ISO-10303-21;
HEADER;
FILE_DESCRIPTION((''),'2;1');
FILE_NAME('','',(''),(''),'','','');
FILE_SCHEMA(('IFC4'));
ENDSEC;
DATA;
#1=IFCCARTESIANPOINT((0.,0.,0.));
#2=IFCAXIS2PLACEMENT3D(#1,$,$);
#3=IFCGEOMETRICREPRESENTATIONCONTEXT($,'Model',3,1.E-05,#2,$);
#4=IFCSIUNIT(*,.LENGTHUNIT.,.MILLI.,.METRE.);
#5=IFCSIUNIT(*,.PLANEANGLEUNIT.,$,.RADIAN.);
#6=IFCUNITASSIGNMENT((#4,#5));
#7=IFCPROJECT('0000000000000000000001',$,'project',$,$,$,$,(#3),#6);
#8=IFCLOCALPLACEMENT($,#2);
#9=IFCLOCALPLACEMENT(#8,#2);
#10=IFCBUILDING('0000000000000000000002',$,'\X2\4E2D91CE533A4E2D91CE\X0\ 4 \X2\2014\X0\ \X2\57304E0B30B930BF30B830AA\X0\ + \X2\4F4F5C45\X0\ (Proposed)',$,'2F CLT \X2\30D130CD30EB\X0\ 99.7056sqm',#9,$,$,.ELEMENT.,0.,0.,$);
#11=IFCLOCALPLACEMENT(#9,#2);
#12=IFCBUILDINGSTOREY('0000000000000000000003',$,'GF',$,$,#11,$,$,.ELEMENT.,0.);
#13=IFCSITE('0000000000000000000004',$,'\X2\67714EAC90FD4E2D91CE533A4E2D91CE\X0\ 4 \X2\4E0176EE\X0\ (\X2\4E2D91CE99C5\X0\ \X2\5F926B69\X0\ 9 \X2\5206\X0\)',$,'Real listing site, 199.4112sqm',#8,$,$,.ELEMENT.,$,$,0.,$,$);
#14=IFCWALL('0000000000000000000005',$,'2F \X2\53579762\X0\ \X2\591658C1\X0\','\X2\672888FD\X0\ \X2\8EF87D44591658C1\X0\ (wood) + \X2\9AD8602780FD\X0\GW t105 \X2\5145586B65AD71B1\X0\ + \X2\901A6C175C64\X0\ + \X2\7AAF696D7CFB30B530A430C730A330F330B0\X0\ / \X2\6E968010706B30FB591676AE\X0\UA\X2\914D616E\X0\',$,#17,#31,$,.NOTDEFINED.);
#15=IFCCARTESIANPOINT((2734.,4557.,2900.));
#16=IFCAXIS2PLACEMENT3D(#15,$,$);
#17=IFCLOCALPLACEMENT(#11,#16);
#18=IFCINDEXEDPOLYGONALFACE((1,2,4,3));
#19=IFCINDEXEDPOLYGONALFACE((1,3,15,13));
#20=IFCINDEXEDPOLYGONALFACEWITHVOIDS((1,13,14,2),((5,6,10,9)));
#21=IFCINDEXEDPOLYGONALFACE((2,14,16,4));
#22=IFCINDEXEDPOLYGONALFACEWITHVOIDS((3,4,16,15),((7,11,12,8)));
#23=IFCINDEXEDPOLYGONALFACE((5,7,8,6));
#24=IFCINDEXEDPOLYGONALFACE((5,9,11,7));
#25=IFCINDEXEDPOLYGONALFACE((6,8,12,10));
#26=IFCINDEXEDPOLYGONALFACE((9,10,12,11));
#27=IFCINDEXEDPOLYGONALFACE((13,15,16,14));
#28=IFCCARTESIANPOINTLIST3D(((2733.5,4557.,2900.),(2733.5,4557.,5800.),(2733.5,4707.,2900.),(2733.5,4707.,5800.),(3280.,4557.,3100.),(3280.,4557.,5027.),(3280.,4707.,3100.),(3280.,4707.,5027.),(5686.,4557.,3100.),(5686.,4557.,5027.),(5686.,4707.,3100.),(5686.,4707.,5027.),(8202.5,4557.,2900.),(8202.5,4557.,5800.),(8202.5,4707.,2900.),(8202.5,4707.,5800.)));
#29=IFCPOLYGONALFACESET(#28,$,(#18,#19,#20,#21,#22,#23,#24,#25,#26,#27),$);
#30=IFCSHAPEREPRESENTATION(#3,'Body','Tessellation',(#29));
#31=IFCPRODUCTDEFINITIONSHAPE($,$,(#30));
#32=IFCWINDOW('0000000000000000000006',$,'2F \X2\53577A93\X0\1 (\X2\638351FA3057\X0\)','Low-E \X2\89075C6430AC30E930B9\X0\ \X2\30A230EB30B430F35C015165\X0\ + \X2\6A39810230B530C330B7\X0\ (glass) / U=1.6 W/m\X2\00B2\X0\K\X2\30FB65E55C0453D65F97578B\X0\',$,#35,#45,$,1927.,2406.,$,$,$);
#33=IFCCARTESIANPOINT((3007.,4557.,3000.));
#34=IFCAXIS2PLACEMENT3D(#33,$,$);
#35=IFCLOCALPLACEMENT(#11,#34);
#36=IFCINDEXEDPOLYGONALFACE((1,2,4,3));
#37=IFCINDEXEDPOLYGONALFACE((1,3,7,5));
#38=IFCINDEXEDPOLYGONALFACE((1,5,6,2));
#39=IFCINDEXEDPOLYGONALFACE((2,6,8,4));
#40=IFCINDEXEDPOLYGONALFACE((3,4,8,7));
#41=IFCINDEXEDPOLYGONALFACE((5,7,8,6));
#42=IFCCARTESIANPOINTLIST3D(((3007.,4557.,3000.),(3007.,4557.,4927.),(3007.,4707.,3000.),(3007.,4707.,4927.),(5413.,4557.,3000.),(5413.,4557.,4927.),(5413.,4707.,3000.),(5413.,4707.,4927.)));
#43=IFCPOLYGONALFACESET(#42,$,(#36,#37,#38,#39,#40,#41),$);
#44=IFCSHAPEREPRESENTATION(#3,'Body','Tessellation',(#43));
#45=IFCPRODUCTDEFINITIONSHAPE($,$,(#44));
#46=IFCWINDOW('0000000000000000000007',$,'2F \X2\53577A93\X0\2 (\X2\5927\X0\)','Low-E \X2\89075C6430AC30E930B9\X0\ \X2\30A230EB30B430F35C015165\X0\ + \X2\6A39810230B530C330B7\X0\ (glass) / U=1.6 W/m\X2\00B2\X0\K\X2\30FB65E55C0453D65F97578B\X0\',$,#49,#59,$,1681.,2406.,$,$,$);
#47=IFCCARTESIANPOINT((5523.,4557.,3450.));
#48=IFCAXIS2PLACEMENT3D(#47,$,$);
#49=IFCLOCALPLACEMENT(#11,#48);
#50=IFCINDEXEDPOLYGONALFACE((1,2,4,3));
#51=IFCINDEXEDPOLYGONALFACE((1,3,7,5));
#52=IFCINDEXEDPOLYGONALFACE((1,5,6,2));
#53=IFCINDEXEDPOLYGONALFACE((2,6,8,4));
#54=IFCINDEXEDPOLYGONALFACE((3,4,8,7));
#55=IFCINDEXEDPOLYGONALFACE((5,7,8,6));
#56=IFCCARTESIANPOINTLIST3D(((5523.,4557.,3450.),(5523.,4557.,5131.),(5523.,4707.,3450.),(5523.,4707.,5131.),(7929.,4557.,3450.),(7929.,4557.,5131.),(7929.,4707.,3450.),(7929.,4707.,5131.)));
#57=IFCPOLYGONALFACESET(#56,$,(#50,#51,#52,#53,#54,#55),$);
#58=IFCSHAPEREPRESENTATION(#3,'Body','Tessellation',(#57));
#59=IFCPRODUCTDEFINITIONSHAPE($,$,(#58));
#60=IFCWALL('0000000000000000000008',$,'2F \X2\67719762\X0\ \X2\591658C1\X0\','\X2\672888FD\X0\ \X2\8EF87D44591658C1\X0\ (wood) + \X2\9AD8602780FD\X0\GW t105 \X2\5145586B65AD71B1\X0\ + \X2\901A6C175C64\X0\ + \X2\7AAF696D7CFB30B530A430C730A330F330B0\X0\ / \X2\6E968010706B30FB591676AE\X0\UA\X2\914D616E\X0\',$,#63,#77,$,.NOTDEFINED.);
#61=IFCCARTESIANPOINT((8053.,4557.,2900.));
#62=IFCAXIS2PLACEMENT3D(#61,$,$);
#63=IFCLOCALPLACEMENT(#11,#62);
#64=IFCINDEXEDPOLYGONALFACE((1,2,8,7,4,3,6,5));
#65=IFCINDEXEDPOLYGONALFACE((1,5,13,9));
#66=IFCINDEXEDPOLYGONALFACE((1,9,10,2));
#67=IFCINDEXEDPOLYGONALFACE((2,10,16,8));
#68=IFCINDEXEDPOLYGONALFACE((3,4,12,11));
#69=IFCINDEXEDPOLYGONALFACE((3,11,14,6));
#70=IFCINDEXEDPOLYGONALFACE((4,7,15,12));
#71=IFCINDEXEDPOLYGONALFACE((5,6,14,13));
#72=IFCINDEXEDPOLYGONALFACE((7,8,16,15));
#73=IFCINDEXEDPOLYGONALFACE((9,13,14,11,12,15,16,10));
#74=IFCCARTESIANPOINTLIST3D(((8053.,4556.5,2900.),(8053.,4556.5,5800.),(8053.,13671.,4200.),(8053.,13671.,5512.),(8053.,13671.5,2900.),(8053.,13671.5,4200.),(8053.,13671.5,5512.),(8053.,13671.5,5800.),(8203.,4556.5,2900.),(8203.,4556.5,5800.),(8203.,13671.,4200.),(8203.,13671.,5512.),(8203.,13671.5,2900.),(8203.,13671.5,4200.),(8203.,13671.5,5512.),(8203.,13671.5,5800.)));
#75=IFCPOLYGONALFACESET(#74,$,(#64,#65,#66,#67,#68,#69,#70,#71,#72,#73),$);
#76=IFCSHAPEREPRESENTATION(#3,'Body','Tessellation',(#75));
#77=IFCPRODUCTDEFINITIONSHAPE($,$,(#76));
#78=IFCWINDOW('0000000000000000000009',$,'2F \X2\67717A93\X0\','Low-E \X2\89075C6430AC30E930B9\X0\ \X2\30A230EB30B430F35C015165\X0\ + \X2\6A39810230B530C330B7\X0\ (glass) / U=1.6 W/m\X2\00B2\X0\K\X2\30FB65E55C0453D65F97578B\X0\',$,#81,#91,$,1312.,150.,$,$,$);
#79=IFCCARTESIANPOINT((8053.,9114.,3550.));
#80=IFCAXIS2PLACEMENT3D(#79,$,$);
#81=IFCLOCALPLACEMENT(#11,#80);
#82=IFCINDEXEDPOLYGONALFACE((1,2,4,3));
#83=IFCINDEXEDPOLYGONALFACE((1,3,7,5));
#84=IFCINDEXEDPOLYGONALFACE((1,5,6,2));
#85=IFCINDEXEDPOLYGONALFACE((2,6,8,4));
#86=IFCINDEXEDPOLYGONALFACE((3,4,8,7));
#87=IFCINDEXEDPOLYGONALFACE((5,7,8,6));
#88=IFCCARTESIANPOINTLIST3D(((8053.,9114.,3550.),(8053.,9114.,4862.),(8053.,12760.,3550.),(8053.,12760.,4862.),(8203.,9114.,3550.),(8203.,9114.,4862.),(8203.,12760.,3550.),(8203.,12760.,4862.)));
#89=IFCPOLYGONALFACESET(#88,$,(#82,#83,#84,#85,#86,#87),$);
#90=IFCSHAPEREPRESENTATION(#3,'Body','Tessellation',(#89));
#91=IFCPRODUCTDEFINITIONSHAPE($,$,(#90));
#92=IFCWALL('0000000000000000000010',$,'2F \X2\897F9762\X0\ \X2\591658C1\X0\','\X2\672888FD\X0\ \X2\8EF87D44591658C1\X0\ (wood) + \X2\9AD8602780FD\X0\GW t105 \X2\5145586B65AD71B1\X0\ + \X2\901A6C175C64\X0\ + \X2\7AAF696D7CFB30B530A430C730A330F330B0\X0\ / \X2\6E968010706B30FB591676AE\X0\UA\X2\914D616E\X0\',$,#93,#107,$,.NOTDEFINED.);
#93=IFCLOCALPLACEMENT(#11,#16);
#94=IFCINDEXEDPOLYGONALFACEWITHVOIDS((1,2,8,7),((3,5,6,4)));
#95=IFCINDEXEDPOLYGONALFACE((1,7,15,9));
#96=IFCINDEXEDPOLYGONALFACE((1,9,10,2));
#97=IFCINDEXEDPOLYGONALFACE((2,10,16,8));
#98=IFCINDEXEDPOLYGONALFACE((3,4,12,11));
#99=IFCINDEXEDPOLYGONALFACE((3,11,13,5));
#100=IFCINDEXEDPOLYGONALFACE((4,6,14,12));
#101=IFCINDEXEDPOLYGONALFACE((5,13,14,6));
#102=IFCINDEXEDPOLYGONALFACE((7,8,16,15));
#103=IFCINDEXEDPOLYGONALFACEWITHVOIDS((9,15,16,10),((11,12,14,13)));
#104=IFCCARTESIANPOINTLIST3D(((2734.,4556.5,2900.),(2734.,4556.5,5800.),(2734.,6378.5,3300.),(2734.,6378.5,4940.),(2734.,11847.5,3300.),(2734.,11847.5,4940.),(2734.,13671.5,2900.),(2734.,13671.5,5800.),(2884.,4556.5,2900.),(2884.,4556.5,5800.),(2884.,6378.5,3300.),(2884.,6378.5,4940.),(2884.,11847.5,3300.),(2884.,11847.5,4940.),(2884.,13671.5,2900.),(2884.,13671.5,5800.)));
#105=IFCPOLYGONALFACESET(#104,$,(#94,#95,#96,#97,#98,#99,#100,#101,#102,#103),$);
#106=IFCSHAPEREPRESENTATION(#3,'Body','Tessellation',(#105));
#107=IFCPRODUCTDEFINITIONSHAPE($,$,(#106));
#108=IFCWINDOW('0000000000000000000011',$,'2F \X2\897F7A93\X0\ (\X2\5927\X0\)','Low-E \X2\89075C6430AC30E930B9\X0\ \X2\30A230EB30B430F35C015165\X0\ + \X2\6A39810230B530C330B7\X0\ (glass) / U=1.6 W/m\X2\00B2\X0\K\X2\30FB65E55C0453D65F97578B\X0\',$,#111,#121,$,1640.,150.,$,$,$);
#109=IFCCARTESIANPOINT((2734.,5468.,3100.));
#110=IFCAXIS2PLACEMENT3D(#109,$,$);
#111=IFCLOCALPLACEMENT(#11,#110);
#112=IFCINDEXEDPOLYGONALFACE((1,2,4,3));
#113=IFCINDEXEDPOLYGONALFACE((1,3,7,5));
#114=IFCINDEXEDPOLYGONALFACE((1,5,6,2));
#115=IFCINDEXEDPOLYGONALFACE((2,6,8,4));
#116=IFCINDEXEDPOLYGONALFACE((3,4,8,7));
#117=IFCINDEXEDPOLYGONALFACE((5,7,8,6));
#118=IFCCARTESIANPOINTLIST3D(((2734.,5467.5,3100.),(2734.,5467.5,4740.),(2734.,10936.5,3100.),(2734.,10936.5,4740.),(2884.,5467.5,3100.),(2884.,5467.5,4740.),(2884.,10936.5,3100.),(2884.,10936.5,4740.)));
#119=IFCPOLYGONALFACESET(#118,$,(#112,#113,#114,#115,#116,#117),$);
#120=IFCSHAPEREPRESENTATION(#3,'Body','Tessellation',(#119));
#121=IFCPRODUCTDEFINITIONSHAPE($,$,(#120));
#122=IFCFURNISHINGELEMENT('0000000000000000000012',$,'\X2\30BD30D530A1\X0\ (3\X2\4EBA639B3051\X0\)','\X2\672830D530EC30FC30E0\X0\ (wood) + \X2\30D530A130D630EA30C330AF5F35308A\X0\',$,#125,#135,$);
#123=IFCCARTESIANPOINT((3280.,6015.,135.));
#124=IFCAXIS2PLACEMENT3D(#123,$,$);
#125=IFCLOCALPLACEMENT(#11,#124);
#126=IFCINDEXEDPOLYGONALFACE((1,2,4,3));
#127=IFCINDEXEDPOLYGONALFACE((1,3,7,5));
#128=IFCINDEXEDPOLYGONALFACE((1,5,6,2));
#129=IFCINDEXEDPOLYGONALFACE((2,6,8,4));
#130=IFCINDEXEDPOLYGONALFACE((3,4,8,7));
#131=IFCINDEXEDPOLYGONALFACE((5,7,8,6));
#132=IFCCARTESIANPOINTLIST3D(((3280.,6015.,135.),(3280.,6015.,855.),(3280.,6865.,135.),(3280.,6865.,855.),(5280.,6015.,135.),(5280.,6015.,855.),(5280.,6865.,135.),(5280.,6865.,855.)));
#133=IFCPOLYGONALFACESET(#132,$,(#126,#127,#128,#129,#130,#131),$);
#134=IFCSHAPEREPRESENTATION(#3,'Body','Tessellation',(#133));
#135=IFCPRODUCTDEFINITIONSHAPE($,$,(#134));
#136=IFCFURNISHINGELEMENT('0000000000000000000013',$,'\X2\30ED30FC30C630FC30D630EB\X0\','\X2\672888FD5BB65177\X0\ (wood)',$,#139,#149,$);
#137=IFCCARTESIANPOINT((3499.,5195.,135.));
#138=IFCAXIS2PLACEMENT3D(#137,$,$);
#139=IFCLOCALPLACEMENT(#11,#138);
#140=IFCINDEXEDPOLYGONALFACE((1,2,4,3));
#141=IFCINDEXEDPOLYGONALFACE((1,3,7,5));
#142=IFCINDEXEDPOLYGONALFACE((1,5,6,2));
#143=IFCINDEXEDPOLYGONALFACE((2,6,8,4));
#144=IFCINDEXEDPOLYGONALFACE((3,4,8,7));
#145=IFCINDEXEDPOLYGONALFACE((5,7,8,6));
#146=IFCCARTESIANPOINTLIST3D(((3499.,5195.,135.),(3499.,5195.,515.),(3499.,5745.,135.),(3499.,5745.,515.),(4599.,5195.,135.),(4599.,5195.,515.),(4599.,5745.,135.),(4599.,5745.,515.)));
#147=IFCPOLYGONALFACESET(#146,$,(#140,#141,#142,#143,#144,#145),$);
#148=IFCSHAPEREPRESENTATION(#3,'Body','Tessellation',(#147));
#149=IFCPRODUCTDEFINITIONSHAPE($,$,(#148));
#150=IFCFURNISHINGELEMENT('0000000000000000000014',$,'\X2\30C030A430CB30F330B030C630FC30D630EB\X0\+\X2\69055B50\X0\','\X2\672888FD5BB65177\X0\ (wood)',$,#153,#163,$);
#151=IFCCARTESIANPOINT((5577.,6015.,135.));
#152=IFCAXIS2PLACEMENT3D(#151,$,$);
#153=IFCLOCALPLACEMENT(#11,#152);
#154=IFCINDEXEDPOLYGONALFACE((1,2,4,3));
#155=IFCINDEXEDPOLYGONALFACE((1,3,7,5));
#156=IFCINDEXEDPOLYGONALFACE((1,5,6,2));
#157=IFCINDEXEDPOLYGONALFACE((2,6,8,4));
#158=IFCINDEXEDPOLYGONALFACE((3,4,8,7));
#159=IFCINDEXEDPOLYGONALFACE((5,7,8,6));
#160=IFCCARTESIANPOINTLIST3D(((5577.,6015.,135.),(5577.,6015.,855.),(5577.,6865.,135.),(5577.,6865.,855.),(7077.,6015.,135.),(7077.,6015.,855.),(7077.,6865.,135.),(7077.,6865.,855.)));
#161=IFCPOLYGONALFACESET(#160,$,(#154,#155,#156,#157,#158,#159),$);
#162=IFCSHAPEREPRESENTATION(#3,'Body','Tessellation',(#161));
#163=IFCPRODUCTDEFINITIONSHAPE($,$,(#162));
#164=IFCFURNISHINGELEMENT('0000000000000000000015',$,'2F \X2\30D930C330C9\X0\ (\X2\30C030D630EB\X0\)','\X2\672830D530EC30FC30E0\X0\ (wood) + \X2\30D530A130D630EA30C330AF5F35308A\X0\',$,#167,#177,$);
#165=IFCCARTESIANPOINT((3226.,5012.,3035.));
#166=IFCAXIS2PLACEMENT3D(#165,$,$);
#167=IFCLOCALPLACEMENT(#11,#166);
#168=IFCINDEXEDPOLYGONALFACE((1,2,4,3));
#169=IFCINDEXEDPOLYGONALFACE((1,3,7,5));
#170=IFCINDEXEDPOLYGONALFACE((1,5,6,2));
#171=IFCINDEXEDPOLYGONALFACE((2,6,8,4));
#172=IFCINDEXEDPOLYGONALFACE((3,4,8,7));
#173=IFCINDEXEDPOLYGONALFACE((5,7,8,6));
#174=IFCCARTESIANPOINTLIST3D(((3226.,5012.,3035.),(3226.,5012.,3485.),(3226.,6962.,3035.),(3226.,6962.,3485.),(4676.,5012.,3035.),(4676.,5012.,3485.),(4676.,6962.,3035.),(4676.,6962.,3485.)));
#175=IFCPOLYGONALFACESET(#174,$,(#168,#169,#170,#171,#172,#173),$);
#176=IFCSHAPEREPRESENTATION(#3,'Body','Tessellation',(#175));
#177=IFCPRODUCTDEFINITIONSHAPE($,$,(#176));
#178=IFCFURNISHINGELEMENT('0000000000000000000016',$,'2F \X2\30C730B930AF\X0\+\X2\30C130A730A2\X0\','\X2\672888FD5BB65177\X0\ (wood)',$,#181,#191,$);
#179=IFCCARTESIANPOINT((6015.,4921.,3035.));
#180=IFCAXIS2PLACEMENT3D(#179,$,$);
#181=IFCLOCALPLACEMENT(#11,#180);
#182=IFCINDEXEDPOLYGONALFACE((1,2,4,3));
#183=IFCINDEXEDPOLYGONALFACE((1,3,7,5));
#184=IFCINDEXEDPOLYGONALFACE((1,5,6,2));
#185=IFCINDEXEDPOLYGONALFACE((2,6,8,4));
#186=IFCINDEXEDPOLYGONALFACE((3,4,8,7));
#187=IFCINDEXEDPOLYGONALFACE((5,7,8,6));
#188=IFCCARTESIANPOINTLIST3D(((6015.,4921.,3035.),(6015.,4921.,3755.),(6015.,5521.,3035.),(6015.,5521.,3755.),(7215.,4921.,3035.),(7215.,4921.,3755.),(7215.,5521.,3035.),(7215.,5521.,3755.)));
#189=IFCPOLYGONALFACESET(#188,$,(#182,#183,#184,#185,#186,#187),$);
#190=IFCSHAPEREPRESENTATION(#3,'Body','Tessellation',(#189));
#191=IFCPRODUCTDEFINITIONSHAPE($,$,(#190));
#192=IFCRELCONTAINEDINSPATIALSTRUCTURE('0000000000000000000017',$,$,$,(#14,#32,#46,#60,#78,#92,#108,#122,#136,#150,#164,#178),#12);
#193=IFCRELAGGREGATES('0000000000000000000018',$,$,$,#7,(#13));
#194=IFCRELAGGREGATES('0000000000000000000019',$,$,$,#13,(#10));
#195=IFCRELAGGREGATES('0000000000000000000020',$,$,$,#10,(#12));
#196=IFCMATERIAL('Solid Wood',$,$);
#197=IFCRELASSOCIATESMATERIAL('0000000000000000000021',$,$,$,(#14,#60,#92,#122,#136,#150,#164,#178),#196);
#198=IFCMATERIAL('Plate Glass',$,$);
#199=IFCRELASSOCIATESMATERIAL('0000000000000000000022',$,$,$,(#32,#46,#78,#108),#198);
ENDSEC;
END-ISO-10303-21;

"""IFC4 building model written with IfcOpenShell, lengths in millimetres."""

from ifc_helpers import new_model, si_unit, frame, frame_2d, origin, place, context, project, spatial, rectangle, extrude, material, element, fill, save


model = new_model("IFC4")

# Units and contexts
model_context = context("Model", 3, precision=1e-05, world=origin())
ifc_project = project(units=[si_unit("LENGTHUNIT", "METRE", prefix="MILLI"), si_unit("PLANEANGLEUNIT", "RADIAN")], contexts=[model_context])

# Site, building, storey
site_placement = place(None, origin())
site = spatial("IfcSite", under=ifc_project, at=site_placement, Name="東京都中野区中野 4 丁目 (中野駅 徒歩 9 分)", ObjectType="Real listing site, 199.4112sqm", CompositionType="ELEMENT", RefElevation=0.0)
building_placement = place(site_placement, origin())
building = spatial("IfcBuilding", under=site, at=building_placement, Name="中野区中野 4 — 地下スタジオ + 住居 (Proposed)", ObjectType="2F CLT パネル 99.7056sqm", CompositionType="ELEMENT", ElevationOfRefHeight=0.0, ElevationOfTerrain=0.0)
storey_placement = place(building_placement, origin())
storey = spatial("IfcBuildingStorey", under=building, at=storey_placement, Name="GF", CompositionType="ELEMENT", Elevation=0.0)

# Shared definitions
ifc_material_1 = material(Name="Solid Wood")

# Wall, openings, windows
wall_1_placement = place(storey_placement, frame((2734.0, 4557.0, 2900.0)))
wall_1 = element("IfcWall", 1, at=wall_1_placement, inside=storey, material=ifc_material_1, Name="2F 南面 外壁", Description="木製 軸組外壁 (wood) + 高性能GW t105 充填断熱 + 通気層 + 窯業系サイディング / 準耐火・外皮UA配慮", PredefinedType="NOTDEFINED", context=model_context, shape_type="SweptSolid", body=[
    extrude(rectangle(XDim=5469.0, YDim=150.0, at=frame_2d((2734.0, 75.0))), frame((2734.0, 4557.0, 2900.0)), (0.0, 0.0, 1.0), 2900.0),
])
opening_1_placement = place(storey_placement, frame((3007.0, 4557.0, 3000.0)))
opening_1 = element("IfcOpeningElement", 2, at=opening_1_placement, cuts=wall_1, PredefinedType="NOTDEFINED", context=model_context, shape_type="SweptSolid", body=[
    extrude(rectangle(XDim=2406.0, YDim=150.0, at=frame_2d((1203.0, 75.0))), frame((3007.0, 4557.0, 3000.0)), (0.0, 0.0, 1.0), 1927.0),
])
opening_2_placement = place(storey_placement, frame((5523.0, 4557.0, 3450.0)))
opening_2 = element("IfcOpeningElement", 3, at=opening_2_placement, cuts=wall_1, PredefinedType="NOTDEFINED", context=model_context, shape_type="SweptSolid", body=[
    extrude(rectangle(XDim=2406.0, YDim=150.0, at=frame_2d((1203.0, 75.0))), frame((5523.0, 4557.0, 3450.0)), (0.0, 0.0, 1.0), 1681.0),
])
ifc_material_2 = material(Name="Plate Glass")
window_1_placement = place(storey_placement, frame((3007.0, 4557.0, 3000.0)))
window_1 = element("IfcWindow", 4, at=window_1_placement, inside=storey, material=ifc_material_2, Name="2F 南窓1 (掃出し)", Description="Low-E 複層ガラス アルゴン封入 + 樹脂サッシ (glass) / U=1.6 W/m²K・日射取得型", OverallHeight=1927.0, OverallWidth=2406.0, context=model_context, shape_type="SweptSolid", body=[
    extrude(rectangle(XDim=2406.0, YDim=150.0, at=frame_2d((1203.0, 75.0))), frame((3007.0, 4557.0, 3000.0)), (0.0, 0.0, 1.0), 1927.0),
])
fill(opening_1, window_1)
window_2_placement = place(storey_placement, frame((5523.0, 4557.0, 3450.0)))
window_2 = element("IfcWindow", 5, at=window_2_placement, inside=storey, material=ifc_material_2, Name="2F 南窓2 (大)", Description="Low-E 複層ガラス アルゴン封入 + 樹脂サッシ (glass) / U=1.6 W/m²K・日射取得型", OverallHeight=1681.0, OverallWidth=2406.0, context=model_context, shape_type="SweptSolid", body=[
    extrude(rectangle(XDim=2406.0, YDim=150.0, at=frame_2d((1203.0, 75.0))), frame((5523.0, 4557.0, 3450.0)), (0.0, 0.0, 1.0), 1681.0),
])
fill(opening_2, window_2)

# Walls, openings, windows
wall_2_placement = place(storey_placement, frame((8053.0, 4557.0, 2900.0)))
wall_2 = element("IfcWall", 6, at=wall_2_placement, inside=storey, material=ifc_material_1, Name="2F 東面 外壁", Description="木製 軸組外壁 (wood) + 高性能GW t105 充填断熱 + 通気層 + 窯業系サイディング / 準耐火・外皮UA配慮", PredefinedType="NOTDEFINED", context=model_context, shape_type="SweptSolid", body=[
    extrude(rectangle(XDim=150.0, YDim=9115.0, at=frame_2d((75.0, 4557.0))), frame((8053.0, 4557.0, 2900.0)), (0.0, 0.0, 1.0), 2900.0),
])
opening_3_placement = place(storey_placement, frame((8053.0, 9114.0, 3550.0)))
opening_3 = element("IfcOpeningElement", 7, at=opening_3_placement, cuts=wall_2, PredefinedType="NOTDEFINED", context=model_context, shape_type="SweptSolid", body=[
    extrude(rectangle(XDim=150.0, YDim=3646.0, at=frame_2d((75.0, 1823.0))), frame((8053.0, 9114.0, 3550.0)), (0.0, 0.0, 1.0), 1312.0),
])
window_3_placement = place(storey_placement, frame((8053.0, 9114.0, 3550.0)))
window_3 = element("IfcWindow", 8, at=window_3_placement, inside=storey, material=ifc_material_2, Name="2F 東窓", Description="Low-E 複層ガラス アルゴン封入 + 樹脂サッシ (glass) / U=1.6 W/m²K・日射取得型", OverallHeight=1312.0, OverallWidth=150.0, context=model_context, shape_type="SweptSolid", body=[
    extrude(rectangle(XDim=150.0, YDim=3646.0, at=frame_2d((75.0, 1823.0))), frame((8053.0, 9114.0, 3550.0)), (0.0, 0.0, 1.0), 1312.0),
])
fill(opening_3, window_3)
wall_3_placement = place(storey_placement, frame((2734.0, 4557.0, 2900.0)))
wall_3 = element("IfcWall", 9, at=wall_3_placement, inside=storey, material=ifc_material_1, Name="2F 西面 外壁", Description="木製 軸組外壁 (wood) + 高性能GW t105 充填断熱 + 通気層 + 窯業系サイディング / 準耐火・外皮UA配慮", PredefinedType="NOTDEFINED", context=model_context, shape_type="SweptSolid", body=[
    extrude(rectangle(XDim=150.0, YDim=9115.0, at=frame_2d((75.0, 4557.0))), frame((2734.0, 4557.0, 2900.0)), (0.0, 0.0, 1.0), 2900.0),
])
opening_4_placement = place(storey_placement, frame((2734.0, 5468.0, 3100.0)))
opening_4 = element("IfcOpeningElement", 10, at=opening_4_placement, cuts=wall_3, PredefinedType="NOTDEFINED", context=model_context, shape_type="SweptSolid", body=[
    extrude(rectangle(XDim=150.0, YDim=5469.0, at=frame_2d((75.0, 2734.0))), frame((2734.0, 5468.0, 3100.0)), (0.0, 0.0, 1.0), 1640.0),
])
window_4_placement = place(storey_placement, frame((2734.0, 5468.0, 3100.0)))
window_4 = element("IfcWindow", 11, at=window_4_placement, inside=storey, material=ifc_material_2, Name="2F 西窓 (大)", Description="Low-E 複層ガラス アルゴン封入 + 樹脂サッシ (glass) / U=1.6 W/m²K・日射取得型", OverallHeight=1640.0, OverallWidth=150.0, context=model_context, shape_type="SweptSolid", body=[
    extrude(rectangle(XDim=150.0, YDim=5469.0, at=frame_2d((75.0, 2734.0))), frame((2734.0, 5468.0, 3100.0)), (0.0, 0.0, 1.0), 1640.0),
])
fill(opening_4, window_4)

# Furnishing elements
furnishing_1_placement = place(storey_placement, frame((3280.0, 6015.0, 135.0)))
element("IfcFurnishingElement", 12, at=furnishing_1_placement, inside=storey, material=ifc_material_1, Name="ソファ (3人掛け)", Description="木フレーム (wood) + ファブリック張り", context=model_context, shape_type="SweptSolid", body=[
    extrude(rectangle(XDim=2000.0, YDim=850.0, at=frame_2d((1000.0, 425.0))), frame((3280.0, 6015.0, 135.0)), (0.0, 0.0, 1.0), 720.0),
])
furnishing_2_placement = place(storey_placement, frame((3499.0, 5195.0, 135.0)))
element("IfcFurnishingElement", 13, at=furnishing_2_placement, inside=storey, material=ifc_material_1, Name="ローテーブル", Description="木製家具 (wood)", context=model_context, shape_type="SweptSolid", body=[
    extrude(rectangle(XDim=1100.0, YDim=550.0, at=frame_2d((550.0, 275.0))), frame((3499.0, 5195.0, 135.0)), (0.0, 0.0, 1.0), 380.0),
])
furnishing_3_placement = place(storey_placement, frame((5577.0, 6015.0, 135.0)))
element("IfcFurnishingElement", 14, at=furnishing_3_placement, inside=storey, material=ifc_material_1, Name="ダイニングテーブル+椅子", Description="木製家具 (wood)", context=model_context, shape_type="SweptSolid", body=[
    extrude(rectangle(XDim=1500.0, YDim=850.0, at=frame_2d((750.0, 425.0))), frame((5577.0, 6015.0, 135.0)), (0.0, 0.0, 1.0), 720.0),
])
furnishing_4_placement = place(storey_placement, frame((3226.0, 5012.0, 3035.0)))
element("IfcFurnishingElement", 15, at=furnishing_4_placement, inside=storey, material=ifc_material_1, Name="2F ベッド (ダブル)", Description="木フレーム (wood) + ファブリック張り", context=model_context, shape_type="SweptSolid", body=[
    extrude(rectangle(XDim=1450.0, YDim=1950.0, at=frame_2d((725.0, 975.0))), frame((3226.0, 5012.0, 3035.0)), (0.0, 0.0, 1.0), 450.0),
])
furnishing_5_placement = place(storey_placement, frame((6015.0, 4921.0, 3035.0)))
element("IfcFurnishingElement", 16, at=furnishing_5_placement, inside=storey, material=ifc_material_1, Name="2F デスク+チェア", Description="木製家具 (wood)", context=model_context, shape_type="SweptSolid", body=[
    extrude(rectangle(XDim=1200.0, YDim=600.0, at=frame_2d((600.0, 300.0))), frame((6015.0, 4921.0, 3035.0)), (0.0, 0.0, 1.0), 720.0),
])

save(model, "model.ifc")
